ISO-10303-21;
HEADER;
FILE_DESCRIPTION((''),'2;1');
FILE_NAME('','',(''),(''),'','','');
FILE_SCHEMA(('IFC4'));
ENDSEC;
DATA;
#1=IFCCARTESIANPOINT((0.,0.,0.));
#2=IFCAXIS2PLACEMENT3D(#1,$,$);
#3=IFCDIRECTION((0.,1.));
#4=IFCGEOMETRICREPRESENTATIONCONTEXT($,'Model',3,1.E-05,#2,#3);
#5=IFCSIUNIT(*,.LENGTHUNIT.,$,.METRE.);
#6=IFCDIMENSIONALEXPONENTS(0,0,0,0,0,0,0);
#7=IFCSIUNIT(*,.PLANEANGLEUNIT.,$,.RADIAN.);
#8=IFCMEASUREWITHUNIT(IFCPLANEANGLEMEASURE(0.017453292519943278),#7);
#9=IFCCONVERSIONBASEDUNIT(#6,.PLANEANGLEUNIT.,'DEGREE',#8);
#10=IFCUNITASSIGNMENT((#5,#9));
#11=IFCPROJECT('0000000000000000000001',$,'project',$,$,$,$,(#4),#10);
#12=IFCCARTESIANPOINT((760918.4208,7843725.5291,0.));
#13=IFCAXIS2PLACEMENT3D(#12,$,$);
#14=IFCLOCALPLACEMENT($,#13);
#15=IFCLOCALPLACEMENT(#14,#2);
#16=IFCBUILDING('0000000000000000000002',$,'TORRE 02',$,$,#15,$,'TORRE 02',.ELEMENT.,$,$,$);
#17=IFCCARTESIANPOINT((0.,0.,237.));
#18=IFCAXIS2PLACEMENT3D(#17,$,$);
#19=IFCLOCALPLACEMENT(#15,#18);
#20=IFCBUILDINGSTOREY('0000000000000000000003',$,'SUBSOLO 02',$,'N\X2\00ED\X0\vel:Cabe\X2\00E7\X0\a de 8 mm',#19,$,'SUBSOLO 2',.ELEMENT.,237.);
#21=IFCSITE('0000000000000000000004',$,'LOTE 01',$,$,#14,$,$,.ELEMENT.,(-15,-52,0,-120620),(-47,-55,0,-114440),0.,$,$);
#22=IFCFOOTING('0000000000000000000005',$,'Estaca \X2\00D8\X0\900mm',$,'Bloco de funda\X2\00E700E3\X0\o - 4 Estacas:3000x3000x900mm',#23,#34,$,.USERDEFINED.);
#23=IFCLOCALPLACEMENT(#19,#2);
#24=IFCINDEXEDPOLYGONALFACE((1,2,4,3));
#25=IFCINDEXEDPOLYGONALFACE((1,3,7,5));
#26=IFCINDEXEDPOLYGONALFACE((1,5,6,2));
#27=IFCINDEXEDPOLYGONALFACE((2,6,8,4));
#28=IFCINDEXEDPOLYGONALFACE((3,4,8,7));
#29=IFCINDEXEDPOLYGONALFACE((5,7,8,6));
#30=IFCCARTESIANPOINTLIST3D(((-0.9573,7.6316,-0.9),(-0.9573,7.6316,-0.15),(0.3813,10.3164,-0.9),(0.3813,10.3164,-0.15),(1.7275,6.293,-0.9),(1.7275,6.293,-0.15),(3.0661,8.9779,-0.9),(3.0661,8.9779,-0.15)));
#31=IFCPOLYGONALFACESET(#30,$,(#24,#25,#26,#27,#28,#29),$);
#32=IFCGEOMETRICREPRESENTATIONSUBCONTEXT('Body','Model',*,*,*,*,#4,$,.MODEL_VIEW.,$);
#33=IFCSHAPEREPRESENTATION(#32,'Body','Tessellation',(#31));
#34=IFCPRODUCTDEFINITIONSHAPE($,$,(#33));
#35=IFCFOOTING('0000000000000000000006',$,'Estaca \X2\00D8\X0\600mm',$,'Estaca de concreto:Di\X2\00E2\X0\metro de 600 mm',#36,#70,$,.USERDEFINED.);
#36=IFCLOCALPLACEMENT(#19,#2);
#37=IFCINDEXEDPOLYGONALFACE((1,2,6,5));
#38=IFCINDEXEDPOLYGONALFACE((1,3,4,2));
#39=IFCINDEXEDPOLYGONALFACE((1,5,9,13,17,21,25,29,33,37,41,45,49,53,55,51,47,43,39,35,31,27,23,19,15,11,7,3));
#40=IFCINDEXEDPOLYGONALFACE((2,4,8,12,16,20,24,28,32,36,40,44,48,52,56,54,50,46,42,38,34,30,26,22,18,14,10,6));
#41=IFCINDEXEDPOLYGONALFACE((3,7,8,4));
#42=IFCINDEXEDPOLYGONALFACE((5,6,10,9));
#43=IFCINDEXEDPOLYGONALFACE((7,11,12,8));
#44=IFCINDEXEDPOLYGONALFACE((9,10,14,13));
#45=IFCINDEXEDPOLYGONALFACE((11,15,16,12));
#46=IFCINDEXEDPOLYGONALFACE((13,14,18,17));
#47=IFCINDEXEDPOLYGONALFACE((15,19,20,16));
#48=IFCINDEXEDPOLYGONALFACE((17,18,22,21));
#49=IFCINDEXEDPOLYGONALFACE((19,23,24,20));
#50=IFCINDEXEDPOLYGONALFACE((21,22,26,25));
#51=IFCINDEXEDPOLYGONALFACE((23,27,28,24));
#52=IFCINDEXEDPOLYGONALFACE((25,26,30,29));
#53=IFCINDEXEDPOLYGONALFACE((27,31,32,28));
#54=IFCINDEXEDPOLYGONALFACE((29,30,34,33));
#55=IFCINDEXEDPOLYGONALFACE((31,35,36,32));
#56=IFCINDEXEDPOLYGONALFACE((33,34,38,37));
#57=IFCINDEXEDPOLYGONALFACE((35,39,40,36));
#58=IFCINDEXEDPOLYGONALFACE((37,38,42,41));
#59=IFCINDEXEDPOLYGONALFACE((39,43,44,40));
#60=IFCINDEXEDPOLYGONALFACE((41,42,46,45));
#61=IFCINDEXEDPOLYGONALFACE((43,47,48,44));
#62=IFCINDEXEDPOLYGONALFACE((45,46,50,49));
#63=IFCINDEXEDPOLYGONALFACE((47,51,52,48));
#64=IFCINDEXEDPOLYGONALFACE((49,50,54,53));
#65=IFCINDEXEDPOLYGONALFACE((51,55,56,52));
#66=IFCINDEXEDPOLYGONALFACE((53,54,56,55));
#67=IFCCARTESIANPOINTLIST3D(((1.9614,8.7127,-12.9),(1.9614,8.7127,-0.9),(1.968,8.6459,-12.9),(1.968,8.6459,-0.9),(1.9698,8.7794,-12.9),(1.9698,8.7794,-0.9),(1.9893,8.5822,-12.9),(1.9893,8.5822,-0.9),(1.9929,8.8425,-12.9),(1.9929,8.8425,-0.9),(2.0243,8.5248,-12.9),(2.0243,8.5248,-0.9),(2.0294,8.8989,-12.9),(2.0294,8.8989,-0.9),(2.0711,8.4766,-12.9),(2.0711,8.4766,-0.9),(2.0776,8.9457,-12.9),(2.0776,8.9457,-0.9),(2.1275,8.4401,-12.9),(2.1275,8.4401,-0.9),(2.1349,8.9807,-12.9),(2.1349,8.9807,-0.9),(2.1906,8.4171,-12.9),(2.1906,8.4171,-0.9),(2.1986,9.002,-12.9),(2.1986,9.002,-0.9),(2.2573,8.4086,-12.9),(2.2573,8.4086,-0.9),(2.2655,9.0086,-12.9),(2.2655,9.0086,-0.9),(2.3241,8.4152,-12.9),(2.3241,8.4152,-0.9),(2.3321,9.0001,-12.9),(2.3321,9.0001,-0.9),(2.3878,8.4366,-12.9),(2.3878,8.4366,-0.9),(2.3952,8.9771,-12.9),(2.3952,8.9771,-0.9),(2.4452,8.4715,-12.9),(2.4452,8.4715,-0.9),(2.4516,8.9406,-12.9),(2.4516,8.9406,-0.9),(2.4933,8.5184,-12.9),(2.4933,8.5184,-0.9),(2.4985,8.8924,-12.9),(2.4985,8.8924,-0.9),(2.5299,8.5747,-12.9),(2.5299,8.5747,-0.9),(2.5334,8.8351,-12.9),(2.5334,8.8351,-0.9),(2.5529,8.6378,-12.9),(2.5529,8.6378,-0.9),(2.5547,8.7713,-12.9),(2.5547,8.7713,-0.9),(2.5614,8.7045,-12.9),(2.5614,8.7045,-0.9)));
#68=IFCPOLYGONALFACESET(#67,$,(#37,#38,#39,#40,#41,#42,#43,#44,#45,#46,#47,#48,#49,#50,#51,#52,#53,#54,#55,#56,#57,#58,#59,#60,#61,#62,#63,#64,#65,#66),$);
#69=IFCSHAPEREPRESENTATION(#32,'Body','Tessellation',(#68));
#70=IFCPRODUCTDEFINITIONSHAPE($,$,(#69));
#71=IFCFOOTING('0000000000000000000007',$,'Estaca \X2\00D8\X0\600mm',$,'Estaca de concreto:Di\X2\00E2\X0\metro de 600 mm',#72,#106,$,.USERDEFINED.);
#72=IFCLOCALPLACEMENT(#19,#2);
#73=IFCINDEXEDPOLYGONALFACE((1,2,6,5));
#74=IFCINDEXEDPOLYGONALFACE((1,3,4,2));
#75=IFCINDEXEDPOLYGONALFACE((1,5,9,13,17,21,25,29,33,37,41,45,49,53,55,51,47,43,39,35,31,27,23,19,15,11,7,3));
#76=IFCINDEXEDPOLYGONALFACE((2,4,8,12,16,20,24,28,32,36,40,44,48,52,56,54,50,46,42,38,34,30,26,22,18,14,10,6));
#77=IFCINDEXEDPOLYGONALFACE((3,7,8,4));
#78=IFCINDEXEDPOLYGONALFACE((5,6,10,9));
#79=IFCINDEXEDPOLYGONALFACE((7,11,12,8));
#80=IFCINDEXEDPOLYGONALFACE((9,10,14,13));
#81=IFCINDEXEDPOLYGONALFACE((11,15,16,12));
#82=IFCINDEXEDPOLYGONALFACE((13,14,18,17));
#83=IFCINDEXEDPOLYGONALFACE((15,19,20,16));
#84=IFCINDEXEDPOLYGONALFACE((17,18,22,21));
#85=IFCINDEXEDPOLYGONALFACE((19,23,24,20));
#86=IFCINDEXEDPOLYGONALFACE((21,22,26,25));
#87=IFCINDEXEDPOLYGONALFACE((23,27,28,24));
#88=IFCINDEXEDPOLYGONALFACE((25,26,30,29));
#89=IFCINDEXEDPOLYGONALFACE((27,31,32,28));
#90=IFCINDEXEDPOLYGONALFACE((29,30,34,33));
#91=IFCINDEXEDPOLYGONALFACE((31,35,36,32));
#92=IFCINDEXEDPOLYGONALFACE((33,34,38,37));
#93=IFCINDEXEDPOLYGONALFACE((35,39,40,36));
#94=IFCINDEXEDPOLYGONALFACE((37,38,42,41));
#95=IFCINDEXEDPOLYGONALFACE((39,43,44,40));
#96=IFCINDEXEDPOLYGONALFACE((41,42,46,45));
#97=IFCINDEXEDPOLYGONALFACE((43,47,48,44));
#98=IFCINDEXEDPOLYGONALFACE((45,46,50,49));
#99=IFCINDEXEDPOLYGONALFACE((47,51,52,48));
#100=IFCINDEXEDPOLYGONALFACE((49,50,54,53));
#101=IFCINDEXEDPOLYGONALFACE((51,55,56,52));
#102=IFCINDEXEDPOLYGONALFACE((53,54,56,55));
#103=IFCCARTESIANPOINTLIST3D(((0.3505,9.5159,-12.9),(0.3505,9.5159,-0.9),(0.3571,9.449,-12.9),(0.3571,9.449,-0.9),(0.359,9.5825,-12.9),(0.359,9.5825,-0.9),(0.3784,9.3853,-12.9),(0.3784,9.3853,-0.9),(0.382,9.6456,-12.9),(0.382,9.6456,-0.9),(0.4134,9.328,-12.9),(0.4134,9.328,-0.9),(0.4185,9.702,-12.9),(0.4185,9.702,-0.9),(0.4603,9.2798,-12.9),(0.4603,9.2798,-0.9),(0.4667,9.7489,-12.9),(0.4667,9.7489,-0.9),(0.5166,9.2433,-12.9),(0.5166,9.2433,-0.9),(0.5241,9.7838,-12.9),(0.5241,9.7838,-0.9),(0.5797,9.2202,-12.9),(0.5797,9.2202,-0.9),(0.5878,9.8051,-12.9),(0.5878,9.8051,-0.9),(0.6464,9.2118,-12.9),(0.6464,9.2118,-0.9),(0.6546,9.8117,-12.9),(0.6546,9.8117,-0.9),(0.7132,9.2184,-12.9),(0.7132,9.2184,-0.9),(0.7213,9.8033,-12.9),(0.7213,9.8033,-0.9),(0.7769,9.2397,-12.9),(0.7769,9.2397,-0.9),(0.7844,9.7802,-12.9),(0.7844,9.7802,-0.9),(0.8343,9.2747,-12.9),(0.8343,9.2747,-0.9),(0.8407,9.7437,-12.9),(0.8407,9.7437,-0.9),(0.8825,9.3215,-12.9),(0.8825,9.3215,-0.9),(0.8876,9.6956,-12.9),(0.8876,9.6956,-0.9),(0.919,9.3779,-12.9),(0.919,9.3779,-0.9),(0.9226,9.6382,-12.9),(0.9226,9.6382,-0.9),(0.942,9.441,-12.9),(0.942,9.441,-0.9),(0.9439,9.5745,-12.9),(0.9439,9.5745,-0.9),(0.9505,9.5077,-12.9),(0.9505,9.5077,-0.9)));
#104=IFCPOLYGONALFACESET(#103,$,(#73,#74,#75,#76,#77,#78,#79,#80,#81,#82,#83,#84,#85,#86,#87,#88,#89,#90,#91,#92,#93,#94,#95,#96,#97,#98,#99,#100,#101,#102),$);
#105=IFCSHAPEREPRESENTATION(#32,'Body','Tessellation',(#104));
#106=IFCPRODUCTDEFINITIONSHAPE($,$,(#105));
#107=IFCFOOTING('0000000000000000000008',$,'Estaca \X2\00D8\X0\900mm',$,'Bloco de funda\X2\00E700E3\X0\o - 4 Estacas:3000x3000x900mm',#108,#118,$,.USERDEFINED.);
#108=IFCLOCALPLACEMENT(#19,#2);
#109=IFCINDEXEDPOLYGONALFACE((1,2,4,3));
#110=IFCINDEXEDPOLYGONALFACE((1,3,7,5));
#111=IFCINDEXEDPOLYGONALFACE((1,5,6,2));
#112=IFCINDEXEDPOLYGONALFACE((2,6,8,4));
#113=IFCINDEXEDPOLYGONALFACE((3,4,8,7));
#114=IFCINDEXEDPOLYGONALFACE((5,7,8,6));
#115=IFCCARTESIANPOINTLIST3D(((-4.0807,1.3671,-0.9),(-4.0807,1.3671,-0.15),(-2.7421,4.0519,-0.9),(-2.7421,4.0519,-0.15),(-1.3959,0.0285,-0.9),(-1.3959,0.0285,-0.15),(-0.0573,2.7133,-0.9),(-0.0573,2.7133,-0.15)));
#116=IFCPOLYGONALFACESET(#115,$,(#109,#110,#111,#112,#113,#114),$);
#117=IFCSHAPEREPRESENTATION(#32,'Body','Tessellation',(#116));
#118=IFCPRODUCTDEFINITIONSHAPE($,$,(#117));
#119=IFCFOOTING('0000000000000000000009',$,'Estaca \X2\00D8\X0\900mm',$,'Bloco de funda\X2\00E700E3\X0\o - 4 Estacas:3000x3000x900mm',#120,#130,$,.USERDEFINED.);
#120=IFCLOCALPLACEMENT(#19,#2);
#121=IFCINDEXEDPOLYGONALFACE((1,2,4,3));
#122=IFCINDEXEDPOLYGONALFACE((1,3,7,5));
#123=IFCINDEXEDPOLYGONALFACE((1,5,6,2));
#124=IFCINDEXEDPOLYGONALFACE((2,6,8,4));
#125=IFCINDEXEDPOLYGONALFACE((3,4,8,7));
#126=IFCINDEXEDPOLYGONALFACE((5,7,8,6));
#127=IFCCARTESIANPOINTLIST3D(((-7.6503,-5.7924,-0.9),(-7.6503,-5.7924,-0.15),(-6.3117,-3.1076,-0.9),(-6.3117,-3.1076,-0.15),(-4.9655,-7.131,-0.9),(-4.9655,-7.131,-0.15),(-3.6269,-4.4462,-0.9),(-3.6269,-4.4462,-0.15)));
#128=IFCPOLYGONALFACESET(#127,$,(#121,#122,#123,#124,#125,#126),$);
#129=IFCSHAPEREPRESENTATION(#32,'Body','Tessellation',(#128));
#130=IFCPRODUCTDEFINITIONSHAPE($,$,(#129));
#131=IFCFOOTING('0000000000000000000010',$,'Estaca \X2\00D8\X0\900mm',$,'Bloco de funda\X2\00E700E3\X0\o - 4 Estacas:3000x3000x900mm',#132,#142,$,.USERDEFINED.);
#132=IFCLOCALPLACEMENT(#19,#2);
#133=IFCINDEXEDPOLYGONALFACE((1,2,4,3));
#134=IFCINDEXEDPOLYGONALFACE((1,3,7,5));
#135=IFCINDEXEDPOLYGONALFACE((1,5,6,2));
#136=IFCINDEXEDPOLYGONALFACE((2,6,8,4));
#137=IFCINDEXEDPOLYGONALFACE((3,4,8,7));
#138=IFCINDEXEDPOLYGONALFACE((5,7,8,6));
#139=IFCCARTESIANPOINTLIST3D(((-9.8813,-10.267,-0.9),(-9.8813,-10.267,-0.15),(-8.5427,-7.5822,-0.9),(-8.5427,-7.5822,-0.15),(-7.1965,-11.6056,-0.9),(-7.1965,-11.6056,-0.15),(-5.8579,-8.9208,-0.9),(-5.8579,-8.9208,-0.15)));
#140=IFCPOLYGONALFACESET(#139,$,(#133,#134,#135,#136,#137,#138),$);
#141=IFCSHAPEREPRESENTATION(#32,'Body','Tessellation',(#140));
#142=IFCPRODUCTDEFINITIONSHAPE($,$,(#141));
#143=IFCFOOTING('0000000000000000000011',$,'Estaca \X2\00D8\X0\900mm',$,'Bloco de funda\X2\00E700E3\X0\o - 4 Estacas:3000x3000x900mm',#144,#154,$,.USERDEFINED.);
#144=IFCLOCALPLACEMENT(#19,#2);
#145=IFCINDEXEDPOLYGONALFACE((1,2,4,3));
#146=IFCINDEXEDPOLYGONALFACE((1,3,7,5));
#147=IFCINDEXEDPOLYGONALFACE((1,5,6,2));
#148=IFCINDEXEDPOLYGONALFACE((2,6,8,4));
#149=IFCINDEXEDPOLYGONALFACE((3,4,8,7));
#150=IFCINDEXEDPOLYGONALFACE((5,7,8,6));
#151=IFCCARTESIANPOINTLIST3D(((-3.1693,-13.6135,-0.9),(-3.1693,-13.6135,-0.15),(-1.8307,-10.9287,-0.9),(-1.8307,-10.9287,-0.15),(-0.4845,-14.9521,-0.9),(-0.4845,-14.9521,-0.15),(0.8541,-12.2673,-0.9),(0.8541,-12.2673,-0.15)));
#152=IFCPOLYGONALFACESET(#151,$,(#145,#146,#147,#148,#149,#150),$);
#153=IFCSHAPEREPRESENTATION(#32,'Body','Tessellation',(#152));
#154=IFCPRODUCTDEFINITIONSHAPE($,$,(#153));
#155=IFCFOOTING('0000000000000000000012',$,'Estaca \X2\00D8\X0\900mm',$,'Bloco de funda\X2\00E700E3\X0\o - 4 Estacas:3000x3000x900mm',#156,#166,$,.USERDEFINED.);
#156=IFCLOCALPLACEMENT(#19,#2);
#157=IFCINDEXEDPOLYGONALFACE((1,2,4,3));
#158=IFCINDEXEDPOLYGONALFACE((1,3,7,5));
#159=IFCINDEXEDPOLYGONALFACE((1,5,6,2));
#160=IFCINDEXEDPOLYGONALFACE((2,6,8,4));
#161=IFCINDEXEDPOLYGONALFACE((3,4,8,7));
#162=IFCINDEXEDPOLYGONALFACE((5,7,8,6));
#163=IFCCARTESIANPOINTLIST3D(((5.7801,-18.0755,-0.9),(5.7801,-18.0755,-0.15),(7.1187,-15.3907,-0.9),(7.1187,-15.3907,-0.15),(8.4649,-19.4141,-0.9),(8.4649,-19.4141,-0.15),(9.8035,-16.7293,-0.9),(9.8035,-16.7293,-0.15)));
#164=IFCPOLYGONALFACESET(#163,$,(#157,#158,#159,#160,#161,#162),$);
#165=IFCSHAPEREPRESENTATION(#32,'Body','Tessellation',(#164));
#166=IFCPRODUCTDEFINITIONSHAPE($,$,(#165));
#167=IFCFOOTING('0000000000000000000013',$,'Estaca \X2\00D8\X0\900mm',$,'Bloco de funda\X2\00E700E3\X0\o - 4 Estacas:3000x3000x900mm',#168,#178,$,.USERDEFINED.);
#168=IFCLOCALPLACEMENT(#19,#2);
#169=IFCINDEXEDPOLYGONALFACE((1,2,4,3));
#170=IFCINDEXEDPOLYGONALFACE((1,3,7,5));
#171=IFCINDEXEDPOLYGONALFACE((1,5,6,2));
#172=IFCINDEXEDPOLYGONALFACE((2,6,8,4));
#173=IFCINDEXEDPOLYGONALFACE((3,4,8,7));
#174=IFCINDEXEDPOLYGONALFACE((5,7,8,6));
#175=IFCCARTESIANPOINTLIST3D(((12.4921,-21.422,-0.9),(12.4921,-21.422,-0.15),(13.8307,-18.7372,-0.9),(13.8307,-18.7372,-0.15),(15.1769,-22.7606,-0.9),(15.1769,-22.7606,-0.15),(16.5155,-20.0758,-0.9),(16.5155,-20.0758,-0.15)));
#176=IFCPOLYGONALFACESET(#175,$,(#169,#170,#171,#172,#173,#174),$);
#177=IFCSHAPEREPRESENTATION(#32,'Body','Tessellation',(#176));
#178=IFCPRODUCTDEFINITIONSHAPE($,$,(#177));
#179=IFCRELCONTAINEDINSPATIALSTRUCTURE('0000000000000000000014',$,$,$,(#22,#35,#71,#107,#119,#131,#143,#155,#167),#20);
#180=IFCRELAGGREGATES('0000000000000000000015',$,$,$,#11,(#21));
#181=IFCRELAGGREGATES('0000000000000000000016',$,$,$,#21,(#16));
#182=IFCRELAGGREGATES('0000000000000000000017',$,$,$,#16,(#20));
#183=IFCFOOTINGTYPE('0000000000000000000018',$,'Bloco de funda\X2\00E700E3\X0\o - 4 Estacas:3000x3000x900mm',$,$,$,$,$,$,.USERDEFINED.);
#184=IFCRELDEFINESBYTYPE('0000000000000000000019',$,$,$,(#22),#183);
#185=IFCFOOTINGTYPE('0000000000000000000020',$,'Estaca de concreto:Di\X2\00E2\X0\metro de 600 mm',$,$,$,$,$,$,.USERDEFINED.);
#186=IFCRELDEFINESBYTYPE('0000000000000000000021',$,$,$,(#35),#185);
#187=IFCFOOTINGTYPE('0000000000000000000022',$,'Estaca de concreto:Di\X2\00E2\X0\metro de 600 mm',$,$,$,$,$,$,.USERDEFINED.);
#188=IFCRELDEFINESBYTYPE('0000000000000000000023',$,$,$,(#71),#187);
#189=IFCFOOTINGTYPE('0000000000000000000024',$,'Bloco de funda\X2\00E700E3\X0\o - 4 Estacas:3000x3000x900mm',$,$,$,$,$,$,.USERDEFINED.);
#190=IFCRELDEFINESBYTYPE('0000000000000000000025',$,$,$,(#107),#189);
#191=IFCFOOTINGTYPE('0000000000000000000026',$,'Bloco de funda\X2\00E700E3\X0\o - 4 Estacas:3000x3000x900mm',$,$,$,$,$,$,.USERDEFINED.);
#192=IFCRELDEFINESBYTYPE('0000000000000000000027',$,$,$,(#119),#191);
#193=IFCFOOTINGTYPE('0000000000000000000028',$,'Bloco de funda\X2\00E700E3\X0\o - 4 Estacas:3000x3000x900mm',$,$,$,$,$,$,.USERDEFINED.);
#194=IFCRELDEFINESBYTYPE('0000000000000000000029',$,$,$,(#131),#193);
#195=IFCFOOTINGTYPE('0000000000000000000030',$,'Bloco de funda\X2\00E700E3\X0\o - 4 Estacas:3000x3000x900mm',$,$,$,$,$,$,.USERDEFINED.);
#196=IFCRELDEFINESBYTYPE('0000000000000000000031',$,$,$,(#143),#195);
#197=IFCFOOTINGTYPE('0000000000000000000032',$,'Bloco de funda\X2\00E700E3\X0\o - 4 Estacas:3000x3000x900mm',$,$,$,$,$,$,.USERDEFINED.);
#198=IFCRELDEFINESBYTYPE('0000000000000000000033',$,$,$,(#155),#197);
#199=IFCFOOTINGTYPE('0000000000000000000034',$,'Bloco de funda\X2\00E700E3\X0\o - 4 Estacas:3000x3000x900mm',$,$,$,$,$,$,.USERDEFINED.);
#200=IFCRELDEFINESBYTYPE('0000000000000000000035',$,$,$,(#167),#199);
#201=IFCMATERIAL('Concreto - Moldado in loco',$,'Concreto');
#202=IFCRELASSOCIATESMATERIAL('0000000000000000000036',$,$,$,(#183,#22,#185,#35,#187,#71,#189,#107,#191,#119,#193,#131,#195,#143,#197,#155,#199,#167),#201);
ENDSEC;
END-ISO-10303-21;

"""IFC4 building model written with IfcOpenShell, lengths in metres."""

from ifc_helpers import new_model, entity, si_unit, converted_unit, direction, frame, origin, place, context, subcontext, project, spatial, arc, indexed_curve, outline, extrude, source, transform, mapped, material, type_object, type_shapes, element, save


model = new_model("IFC4")

# Units and contexts
model_context = context("Model", 3, precision=1e-05, world=origin(), true_north=direction((0.0, 1.0)))
body_context = subcontext(model_context, "Body", "Model", "MODEL_VIEW")
ifc_project = project(units=[si_unit("LENGTHUNIT", "METRE"), converted_unit("PLANEANGLEUNIT", "DEGREE", entity("IfcPlaneAngleMeasure", 0.017453292519943278), si_unit("PLANEANGLEUNIT", "RADIAN"), dimensions=[0, 0, 0, 0, 0, 0, 0])], contexts=[model_context])

# Site, building, storey
site_placement = place(None, frame((760918.4208, 7843725.5291, 0.0)))
site = spatial("IfcSite", under=ifc_project, at=site_placement, Name="LOTE 01", CompositionType="ELEMENT", RefLatitude=(-15, -52, 0, -120620), RefLongitude=(-47, -55, 0, -114440), RefElevation=0.0)
building_placement = place(site_placement, origin())
building = spatial("IfcBuilding", under=site, at=building_placement, Name="TORRE 02", LongName="TORRE 02", CompositionType="ELEMENT")
storey_placement = place(building_placement, frame((0.0, 0.0, 237.0)))
storey = spatial("IfcBuildingStorey", under=building, at=storey_placement, Name="SUBSOLO 02", ObjectType="Nível:Cabeça de 8 mm", LongName="SUBSOLO 2", CompositionType="ELEMENT", Elevation=237.0)

# Footings
ifc_material_1 = material(Name="Concreto - Moldado in loco", Category="Concreto")
footing_type_1 = type_object("IfcFootingType", Name="Bloco de fundação - 4 Estacas:3000x3000x900mm", PredefinedType="USERDEFINED", material=ifc_material_1)
shared_shape_1 = source(origin(), body_context, "Body", "SweptSolid", [
    extrude(outline(indexed_curve([(-1.5, -1.5), (1.5, -1.5), (1.5, 1.5), (-1.5, 1.5), (-1.5, -1.5)], self_intersect=False)), frame((1.0544, 8.3047, -0.9), z_axis=(0.0, 0.0, 1.0), x_axis=(-0.894934, 0.446198, 0.0)), (0.0, 0.0, 1.0), 0.75),
])
type_shapes(footing_type_1, [shared_shape_1])
placement = place(building_placement, frame((0.0, 0.0, 237.0)))
footing_1_placement = place(placement, origin())
element("IfcFooting", 1, at=footing_1_placement, inside=storey, type_object=footing_type_1, material=ifc_material_1, Name="Estaca Ø900mm", ObjectType="Bloco de fundação - 4 Estacas:3000x3000x900mm", PredefinedType="USERDEFINED", context=body_context, shape_type="MappedRepresentation", body=[
    mapped(shared_shape_1, transform((0.0, 0.0, 0.0), scale=1.0)),
])
footing_type_2 = type_object("IfcFootingType", Name="Estaca de concreto:Diâmetro de 600 mm", PredefinedType="USERDEFINED", material=ifc_material_1)
shared_shape_2 = source(origin(), body_context, "Body", "SweptSolid", [
    extrude(outline(indexed_curve([(-0.3, 0.0), (0.0, -0.3), (0.3, 0.0), (0.0, 0.3)], segments=[arc(1, 2, 3), arc(3, 4, 1)], self_intersect=False)), frame((2.2614, 8.7086, -12.0), z_axis=(0.0, 0.0, 1.0), x_axis=(0.894934, -0.446198, 0.0)), (0.0, 0.0, 1.0), 12.0),
])
type_shapes(footing_type_2, [shared_shape_2])
footing_2_placement = place(placement, frame((0.0, 0.0, -0.9)))
element("IfcFooting", 2, at=footing_2_placement, inside=storey, type_object=footing_type_2, material=ifc_material_1, Name="Estaca Ø600mm", ObjectType="Estaca de concreto:Diâmetro de 600 mm", PredefinedType="USERDEFINED", context=body_context, shape_type="MappedRepresentation", body=[
    mapped(shared_shape_2, transform((0.0, 0.0, 0.0), scale=1.0)),
])
footing_type_3 = type_object("IfcFootingType", Name="Estaca de concreto:Diâmetro de 600 mm", PredefinedType="USERDEFINED", material=ifc_material_1)
shared_shape_3 = source(origin(), body_context, "Body", "SweptSolid", [
    extrude(outline(indexed_curve([(-0.3, 0.0), (0.0, -0.3), (0.3, 0.0), (0.0, 0.3)], segments=[arc(1, 2, 3), arc(3, 4, 1)], self_intersect=False)), frame((0.6505, 9.5118, -12.0), z_axis=(0.0, 0.0, 1.0), x_axis=(0.894934, -0.446198, 0.0)), (0.0, 0.0, 1.0), 12.0),
])
type_shapes(footing_type_3, [shared_shape_3])
footing_3_placement = place(placement, frame((0.0, 0.0, -0.9)))
element("IfcFooting", 3, at=footing_3_placement, inside=storey, type_object=footing_type_3, material=ifc_material_1, Name="Estaca Ø600mm", ObjectType="Estaca de concreto:Diâmetro de 600 mm", PredefinedType="USERDEFINED", context=body_context, shape_type="MappedRepresentation", body=[
    mapped(shared_shape_3, transform((0.0, 0.0, 0.0), scale=1.0)),
])
footing_type_4 = type_object("IfcFootingType", Name="Bloco de fundação - 4 Estacas:3000x3000x900mm", PredefinedType="USERDEFINED", material=ifc_material_1)
shared_shape_4 = source(origin(), body_context, "Body", "SweptSolid", [
    extrude(outline(indexed_curve([(-1.5, -1.5), (1.5, -1.5), (1.5, 1.5), (-1.5, 1.5), (-1.5, -1.5)], self_intersect=False)), frame((-2.069, 2.0402, -0.9), z_axis=(0.0, 0.0, 1.0), x_axis=(-0.894934, 0.446198, 0.0)), (0.0, 0.0, 1.0), 0.75),
])
type_shapes(footing_type_4, [shared_shape_4])
footing_4_placement = place(placement, origin())
element("IfcFooting", 4, at=footing_4_placement, inside=storey, type_object=footing_type_4, material=ifc_material_1, Name="Estaca Ø900mm", ObjectType="Bloco de fundação - 4 Estacas:3000x3000x900mm", PredefinedType="USERDEFINED", context=body_context, shape_type="MappedRepresentation", body=[
    mapped(shared_shape_4, transform((0.0, 0.0, 0.0), scale=1.0)),
])
footing_type_5 = type_object("IfcFootingType", Name="Bloco de fundação - 4 Estacas:3000x3000x900mm", PredefinedType="USERDEFINED", material=ifc_material_1)
shared_shape_5 = source(origin(), body_context, "Body", "SweptSolid", [
    extrude(outline(indexed_curve([(-1.5, -1.5), (1.5, -1.5), (1.5, 1.5), (-1.5, 1.5), (-1.5, -1.5)], self_intersect=False)), frame((-5.6386, -5.1193, -0.9), z_axis=(0.0, 0.0, 1.0), x_axis=(-0.894934, 0.446198, 0.0)), (0.0, 0.0, 1.0), 0.75),
])
type_shapes(footing_type_5, [shared_shape_5])
footing_5_placement = place(placement, origin())
element("IfcFooting", 5, at=footing_5_placement, inside=storey, type_object=footing_type_5, material=ifc_material_1, Name="Estaca Ø900mm", ObjectType="Bloco de fundação - 4 Estacas:3000x3000x900mm", PredefinedType="USERDEFINED", context=body_context, shape_type="MappedRepresentation", body=[
    mapped(shared_shape_5, transform((0.0, 0.0, 0.0), scale=1.0)),
])
footing_type_6 = type_object("IfcFootingType", Name="Bloco de fundação - 4 Estacas:3000x3000x900mm", PredefinedType="USERDEFINED", material=ifc_material_1)
shared_shape_6 = source(origin(), body_context, "Body", "SweptSolid", [
    extrude(outline(indexed_curve([(-1.5, -1.5), (1.5, -1.5), (1.5, 1.5), (-1.5, 1.5), (-1.5, -1.5)], self_intersect=False)), frame((-7.8696, -9.5939, -0.9), z_axis=(0.0, 0.0, 1.0), x_axis=(-0.894934, 0.446198, 0.0)), (0.0, 0.0, 1.0), 0.75),
])
type_shapes(footing_type_6, [shared_shape_6])
footing_6_placement = place(placement, origin())
element("IfcFooting", 6, at=footing_6_placement, inside=storey, type_object=footing_type_6, material=ifc_material_1, Name="Estaca Ø900mm", ObjectType="Bloco de fundação - 4 Estacas:3000x3000x900mm", PredefinedType="USERDEFINED", context=body_context, shape_type="MappedRepresentation", body=[
    mapped(shared_shape_6, transform((0.0, 0.0, 0.0), scale=1.0)),
])
footing_type_7 = type_object("IfcFootingType", Name="Bloco de fundação - 4 Estacas:3000x3000x900mm", PredefinedType="USERDEFINED", material=ifc_material_1)
shared_shape_7 = source(origin(), body_context, "Body", "SweptSolid", [
    extrude(outline(indexed_curve([(-1.5, -1.5), (1.5, -1.5), (1.5, 1.5), (-1.5, 1.5), (-1.5, -1.5)], self_intersect=False)), frame((-1.1576, -12.9404, -0.9), z_axis=(0.0, 0.0, 1.0), x_axis=(-0.894934, 0.446198, 0.0)), (0.0, 0.0, 1.0), 0.75),
])
type_shapes(footing_type_7, [shared_shape_7])
footing_7_placement = place(placement, origin())
element("IfcFooting", 7, at=footing_7_placement, inside=storey, type_object=footing_type_7, material=ifc_material_1, Name="Estaca Ø900mm", ObjectType="Bloco de fundação - 4 Estacas:3000x3000x900mm", PredefinedType="USERDEFINED", context=body_context, shape_type="MappedRepresentation", body=[
    mapped(shared_shape_7, transform((0.0, 0.0, 0.0), scale=1.0)),
])
footing_type_8 = type_object("IfcFootingType", Name="Bloco de fundação - 4 Estacas:3000x3000x900mm", PredefinedType="USERDEFINED", material=ifc_material_1)
shared_shape_8 = source(origin(), body_context, "Body", "SweptSolid", [
    extrude(outline(indexed_curve([(-1.5, -1.5), (1.5, -1.5), (1.5, 1.5), (-1.5, 1.5), (-1.5, -1.5)], self_intersect=False)), frame((7.7918, -17.4024, -0.9), z_axis=(0.0, 0.0, 1.0), x_axis=(-0.894934, 0.446198, 0.0)), (0.0, 0.0, 1.0), 0.75),
])
type_shapes(footing_type_8, [shared_shape_8])
footing_8_placement = place(placement, origin())
element("IfcFooting", 8, at=footing_8_placement, inside=storey, type_object=footing_type_8, material=ifc_material_1, Name="Estaca Ø900mm", ObjectType="Bloco de fundação - 4 Estacas:3000x3000x900mm", PredefinedType="USERDEFINED", context=body_context, shape_type="MappedRepresentation", body=[
    mapped(shared_shape_8, transform((0.0, 0.0, 0.0), scale=1.0)),
])
footing_type_9 = type_object("IfcFootingType", Name="Bloco de fundação - 4 Estacas:3000x3000x900mm", PredefinedType="USERDEFINED", material=ifc_material_1)
shared_shape_9 = source(origin(), body_context, "Body", "SweptSolid", [
    extrude(outline(indexed_curve([(-1.5, -1.5), (1.5, -1.5), (1.5, 1.5), (-1.5, 1.5), (-1.5, -1.5)], self_intersect=False)), frame((14.5038, -20.7489, -0.9), z_axis=(0.0, 0.0, 1.0), x_axis=(-0.894934, 0.446198, 0.0)), (0.0, 0.0, 1.0), 0.75),
])
type_shapes(footing_type_9, [shared_shape_9])
footing_9_placement = place(placement, origin())
element("IfcFooting", 9, at=footing_9_placement, inside=storey, type_object=footing_type_9, material=ifc_material_1, Name="Estaca Ø900mm", ObjectType="Bloco de fundação - 4 Estacas:3000x3000x900mm", PredefinedType="USERDEFINED", context=body_context, shape_type="MappedRepresentation", body=[
    mapped(shared_shape_9, transform((0.0, 0.0, 0.0), scale=1.0)),
])

save(model, "model.ifc")
